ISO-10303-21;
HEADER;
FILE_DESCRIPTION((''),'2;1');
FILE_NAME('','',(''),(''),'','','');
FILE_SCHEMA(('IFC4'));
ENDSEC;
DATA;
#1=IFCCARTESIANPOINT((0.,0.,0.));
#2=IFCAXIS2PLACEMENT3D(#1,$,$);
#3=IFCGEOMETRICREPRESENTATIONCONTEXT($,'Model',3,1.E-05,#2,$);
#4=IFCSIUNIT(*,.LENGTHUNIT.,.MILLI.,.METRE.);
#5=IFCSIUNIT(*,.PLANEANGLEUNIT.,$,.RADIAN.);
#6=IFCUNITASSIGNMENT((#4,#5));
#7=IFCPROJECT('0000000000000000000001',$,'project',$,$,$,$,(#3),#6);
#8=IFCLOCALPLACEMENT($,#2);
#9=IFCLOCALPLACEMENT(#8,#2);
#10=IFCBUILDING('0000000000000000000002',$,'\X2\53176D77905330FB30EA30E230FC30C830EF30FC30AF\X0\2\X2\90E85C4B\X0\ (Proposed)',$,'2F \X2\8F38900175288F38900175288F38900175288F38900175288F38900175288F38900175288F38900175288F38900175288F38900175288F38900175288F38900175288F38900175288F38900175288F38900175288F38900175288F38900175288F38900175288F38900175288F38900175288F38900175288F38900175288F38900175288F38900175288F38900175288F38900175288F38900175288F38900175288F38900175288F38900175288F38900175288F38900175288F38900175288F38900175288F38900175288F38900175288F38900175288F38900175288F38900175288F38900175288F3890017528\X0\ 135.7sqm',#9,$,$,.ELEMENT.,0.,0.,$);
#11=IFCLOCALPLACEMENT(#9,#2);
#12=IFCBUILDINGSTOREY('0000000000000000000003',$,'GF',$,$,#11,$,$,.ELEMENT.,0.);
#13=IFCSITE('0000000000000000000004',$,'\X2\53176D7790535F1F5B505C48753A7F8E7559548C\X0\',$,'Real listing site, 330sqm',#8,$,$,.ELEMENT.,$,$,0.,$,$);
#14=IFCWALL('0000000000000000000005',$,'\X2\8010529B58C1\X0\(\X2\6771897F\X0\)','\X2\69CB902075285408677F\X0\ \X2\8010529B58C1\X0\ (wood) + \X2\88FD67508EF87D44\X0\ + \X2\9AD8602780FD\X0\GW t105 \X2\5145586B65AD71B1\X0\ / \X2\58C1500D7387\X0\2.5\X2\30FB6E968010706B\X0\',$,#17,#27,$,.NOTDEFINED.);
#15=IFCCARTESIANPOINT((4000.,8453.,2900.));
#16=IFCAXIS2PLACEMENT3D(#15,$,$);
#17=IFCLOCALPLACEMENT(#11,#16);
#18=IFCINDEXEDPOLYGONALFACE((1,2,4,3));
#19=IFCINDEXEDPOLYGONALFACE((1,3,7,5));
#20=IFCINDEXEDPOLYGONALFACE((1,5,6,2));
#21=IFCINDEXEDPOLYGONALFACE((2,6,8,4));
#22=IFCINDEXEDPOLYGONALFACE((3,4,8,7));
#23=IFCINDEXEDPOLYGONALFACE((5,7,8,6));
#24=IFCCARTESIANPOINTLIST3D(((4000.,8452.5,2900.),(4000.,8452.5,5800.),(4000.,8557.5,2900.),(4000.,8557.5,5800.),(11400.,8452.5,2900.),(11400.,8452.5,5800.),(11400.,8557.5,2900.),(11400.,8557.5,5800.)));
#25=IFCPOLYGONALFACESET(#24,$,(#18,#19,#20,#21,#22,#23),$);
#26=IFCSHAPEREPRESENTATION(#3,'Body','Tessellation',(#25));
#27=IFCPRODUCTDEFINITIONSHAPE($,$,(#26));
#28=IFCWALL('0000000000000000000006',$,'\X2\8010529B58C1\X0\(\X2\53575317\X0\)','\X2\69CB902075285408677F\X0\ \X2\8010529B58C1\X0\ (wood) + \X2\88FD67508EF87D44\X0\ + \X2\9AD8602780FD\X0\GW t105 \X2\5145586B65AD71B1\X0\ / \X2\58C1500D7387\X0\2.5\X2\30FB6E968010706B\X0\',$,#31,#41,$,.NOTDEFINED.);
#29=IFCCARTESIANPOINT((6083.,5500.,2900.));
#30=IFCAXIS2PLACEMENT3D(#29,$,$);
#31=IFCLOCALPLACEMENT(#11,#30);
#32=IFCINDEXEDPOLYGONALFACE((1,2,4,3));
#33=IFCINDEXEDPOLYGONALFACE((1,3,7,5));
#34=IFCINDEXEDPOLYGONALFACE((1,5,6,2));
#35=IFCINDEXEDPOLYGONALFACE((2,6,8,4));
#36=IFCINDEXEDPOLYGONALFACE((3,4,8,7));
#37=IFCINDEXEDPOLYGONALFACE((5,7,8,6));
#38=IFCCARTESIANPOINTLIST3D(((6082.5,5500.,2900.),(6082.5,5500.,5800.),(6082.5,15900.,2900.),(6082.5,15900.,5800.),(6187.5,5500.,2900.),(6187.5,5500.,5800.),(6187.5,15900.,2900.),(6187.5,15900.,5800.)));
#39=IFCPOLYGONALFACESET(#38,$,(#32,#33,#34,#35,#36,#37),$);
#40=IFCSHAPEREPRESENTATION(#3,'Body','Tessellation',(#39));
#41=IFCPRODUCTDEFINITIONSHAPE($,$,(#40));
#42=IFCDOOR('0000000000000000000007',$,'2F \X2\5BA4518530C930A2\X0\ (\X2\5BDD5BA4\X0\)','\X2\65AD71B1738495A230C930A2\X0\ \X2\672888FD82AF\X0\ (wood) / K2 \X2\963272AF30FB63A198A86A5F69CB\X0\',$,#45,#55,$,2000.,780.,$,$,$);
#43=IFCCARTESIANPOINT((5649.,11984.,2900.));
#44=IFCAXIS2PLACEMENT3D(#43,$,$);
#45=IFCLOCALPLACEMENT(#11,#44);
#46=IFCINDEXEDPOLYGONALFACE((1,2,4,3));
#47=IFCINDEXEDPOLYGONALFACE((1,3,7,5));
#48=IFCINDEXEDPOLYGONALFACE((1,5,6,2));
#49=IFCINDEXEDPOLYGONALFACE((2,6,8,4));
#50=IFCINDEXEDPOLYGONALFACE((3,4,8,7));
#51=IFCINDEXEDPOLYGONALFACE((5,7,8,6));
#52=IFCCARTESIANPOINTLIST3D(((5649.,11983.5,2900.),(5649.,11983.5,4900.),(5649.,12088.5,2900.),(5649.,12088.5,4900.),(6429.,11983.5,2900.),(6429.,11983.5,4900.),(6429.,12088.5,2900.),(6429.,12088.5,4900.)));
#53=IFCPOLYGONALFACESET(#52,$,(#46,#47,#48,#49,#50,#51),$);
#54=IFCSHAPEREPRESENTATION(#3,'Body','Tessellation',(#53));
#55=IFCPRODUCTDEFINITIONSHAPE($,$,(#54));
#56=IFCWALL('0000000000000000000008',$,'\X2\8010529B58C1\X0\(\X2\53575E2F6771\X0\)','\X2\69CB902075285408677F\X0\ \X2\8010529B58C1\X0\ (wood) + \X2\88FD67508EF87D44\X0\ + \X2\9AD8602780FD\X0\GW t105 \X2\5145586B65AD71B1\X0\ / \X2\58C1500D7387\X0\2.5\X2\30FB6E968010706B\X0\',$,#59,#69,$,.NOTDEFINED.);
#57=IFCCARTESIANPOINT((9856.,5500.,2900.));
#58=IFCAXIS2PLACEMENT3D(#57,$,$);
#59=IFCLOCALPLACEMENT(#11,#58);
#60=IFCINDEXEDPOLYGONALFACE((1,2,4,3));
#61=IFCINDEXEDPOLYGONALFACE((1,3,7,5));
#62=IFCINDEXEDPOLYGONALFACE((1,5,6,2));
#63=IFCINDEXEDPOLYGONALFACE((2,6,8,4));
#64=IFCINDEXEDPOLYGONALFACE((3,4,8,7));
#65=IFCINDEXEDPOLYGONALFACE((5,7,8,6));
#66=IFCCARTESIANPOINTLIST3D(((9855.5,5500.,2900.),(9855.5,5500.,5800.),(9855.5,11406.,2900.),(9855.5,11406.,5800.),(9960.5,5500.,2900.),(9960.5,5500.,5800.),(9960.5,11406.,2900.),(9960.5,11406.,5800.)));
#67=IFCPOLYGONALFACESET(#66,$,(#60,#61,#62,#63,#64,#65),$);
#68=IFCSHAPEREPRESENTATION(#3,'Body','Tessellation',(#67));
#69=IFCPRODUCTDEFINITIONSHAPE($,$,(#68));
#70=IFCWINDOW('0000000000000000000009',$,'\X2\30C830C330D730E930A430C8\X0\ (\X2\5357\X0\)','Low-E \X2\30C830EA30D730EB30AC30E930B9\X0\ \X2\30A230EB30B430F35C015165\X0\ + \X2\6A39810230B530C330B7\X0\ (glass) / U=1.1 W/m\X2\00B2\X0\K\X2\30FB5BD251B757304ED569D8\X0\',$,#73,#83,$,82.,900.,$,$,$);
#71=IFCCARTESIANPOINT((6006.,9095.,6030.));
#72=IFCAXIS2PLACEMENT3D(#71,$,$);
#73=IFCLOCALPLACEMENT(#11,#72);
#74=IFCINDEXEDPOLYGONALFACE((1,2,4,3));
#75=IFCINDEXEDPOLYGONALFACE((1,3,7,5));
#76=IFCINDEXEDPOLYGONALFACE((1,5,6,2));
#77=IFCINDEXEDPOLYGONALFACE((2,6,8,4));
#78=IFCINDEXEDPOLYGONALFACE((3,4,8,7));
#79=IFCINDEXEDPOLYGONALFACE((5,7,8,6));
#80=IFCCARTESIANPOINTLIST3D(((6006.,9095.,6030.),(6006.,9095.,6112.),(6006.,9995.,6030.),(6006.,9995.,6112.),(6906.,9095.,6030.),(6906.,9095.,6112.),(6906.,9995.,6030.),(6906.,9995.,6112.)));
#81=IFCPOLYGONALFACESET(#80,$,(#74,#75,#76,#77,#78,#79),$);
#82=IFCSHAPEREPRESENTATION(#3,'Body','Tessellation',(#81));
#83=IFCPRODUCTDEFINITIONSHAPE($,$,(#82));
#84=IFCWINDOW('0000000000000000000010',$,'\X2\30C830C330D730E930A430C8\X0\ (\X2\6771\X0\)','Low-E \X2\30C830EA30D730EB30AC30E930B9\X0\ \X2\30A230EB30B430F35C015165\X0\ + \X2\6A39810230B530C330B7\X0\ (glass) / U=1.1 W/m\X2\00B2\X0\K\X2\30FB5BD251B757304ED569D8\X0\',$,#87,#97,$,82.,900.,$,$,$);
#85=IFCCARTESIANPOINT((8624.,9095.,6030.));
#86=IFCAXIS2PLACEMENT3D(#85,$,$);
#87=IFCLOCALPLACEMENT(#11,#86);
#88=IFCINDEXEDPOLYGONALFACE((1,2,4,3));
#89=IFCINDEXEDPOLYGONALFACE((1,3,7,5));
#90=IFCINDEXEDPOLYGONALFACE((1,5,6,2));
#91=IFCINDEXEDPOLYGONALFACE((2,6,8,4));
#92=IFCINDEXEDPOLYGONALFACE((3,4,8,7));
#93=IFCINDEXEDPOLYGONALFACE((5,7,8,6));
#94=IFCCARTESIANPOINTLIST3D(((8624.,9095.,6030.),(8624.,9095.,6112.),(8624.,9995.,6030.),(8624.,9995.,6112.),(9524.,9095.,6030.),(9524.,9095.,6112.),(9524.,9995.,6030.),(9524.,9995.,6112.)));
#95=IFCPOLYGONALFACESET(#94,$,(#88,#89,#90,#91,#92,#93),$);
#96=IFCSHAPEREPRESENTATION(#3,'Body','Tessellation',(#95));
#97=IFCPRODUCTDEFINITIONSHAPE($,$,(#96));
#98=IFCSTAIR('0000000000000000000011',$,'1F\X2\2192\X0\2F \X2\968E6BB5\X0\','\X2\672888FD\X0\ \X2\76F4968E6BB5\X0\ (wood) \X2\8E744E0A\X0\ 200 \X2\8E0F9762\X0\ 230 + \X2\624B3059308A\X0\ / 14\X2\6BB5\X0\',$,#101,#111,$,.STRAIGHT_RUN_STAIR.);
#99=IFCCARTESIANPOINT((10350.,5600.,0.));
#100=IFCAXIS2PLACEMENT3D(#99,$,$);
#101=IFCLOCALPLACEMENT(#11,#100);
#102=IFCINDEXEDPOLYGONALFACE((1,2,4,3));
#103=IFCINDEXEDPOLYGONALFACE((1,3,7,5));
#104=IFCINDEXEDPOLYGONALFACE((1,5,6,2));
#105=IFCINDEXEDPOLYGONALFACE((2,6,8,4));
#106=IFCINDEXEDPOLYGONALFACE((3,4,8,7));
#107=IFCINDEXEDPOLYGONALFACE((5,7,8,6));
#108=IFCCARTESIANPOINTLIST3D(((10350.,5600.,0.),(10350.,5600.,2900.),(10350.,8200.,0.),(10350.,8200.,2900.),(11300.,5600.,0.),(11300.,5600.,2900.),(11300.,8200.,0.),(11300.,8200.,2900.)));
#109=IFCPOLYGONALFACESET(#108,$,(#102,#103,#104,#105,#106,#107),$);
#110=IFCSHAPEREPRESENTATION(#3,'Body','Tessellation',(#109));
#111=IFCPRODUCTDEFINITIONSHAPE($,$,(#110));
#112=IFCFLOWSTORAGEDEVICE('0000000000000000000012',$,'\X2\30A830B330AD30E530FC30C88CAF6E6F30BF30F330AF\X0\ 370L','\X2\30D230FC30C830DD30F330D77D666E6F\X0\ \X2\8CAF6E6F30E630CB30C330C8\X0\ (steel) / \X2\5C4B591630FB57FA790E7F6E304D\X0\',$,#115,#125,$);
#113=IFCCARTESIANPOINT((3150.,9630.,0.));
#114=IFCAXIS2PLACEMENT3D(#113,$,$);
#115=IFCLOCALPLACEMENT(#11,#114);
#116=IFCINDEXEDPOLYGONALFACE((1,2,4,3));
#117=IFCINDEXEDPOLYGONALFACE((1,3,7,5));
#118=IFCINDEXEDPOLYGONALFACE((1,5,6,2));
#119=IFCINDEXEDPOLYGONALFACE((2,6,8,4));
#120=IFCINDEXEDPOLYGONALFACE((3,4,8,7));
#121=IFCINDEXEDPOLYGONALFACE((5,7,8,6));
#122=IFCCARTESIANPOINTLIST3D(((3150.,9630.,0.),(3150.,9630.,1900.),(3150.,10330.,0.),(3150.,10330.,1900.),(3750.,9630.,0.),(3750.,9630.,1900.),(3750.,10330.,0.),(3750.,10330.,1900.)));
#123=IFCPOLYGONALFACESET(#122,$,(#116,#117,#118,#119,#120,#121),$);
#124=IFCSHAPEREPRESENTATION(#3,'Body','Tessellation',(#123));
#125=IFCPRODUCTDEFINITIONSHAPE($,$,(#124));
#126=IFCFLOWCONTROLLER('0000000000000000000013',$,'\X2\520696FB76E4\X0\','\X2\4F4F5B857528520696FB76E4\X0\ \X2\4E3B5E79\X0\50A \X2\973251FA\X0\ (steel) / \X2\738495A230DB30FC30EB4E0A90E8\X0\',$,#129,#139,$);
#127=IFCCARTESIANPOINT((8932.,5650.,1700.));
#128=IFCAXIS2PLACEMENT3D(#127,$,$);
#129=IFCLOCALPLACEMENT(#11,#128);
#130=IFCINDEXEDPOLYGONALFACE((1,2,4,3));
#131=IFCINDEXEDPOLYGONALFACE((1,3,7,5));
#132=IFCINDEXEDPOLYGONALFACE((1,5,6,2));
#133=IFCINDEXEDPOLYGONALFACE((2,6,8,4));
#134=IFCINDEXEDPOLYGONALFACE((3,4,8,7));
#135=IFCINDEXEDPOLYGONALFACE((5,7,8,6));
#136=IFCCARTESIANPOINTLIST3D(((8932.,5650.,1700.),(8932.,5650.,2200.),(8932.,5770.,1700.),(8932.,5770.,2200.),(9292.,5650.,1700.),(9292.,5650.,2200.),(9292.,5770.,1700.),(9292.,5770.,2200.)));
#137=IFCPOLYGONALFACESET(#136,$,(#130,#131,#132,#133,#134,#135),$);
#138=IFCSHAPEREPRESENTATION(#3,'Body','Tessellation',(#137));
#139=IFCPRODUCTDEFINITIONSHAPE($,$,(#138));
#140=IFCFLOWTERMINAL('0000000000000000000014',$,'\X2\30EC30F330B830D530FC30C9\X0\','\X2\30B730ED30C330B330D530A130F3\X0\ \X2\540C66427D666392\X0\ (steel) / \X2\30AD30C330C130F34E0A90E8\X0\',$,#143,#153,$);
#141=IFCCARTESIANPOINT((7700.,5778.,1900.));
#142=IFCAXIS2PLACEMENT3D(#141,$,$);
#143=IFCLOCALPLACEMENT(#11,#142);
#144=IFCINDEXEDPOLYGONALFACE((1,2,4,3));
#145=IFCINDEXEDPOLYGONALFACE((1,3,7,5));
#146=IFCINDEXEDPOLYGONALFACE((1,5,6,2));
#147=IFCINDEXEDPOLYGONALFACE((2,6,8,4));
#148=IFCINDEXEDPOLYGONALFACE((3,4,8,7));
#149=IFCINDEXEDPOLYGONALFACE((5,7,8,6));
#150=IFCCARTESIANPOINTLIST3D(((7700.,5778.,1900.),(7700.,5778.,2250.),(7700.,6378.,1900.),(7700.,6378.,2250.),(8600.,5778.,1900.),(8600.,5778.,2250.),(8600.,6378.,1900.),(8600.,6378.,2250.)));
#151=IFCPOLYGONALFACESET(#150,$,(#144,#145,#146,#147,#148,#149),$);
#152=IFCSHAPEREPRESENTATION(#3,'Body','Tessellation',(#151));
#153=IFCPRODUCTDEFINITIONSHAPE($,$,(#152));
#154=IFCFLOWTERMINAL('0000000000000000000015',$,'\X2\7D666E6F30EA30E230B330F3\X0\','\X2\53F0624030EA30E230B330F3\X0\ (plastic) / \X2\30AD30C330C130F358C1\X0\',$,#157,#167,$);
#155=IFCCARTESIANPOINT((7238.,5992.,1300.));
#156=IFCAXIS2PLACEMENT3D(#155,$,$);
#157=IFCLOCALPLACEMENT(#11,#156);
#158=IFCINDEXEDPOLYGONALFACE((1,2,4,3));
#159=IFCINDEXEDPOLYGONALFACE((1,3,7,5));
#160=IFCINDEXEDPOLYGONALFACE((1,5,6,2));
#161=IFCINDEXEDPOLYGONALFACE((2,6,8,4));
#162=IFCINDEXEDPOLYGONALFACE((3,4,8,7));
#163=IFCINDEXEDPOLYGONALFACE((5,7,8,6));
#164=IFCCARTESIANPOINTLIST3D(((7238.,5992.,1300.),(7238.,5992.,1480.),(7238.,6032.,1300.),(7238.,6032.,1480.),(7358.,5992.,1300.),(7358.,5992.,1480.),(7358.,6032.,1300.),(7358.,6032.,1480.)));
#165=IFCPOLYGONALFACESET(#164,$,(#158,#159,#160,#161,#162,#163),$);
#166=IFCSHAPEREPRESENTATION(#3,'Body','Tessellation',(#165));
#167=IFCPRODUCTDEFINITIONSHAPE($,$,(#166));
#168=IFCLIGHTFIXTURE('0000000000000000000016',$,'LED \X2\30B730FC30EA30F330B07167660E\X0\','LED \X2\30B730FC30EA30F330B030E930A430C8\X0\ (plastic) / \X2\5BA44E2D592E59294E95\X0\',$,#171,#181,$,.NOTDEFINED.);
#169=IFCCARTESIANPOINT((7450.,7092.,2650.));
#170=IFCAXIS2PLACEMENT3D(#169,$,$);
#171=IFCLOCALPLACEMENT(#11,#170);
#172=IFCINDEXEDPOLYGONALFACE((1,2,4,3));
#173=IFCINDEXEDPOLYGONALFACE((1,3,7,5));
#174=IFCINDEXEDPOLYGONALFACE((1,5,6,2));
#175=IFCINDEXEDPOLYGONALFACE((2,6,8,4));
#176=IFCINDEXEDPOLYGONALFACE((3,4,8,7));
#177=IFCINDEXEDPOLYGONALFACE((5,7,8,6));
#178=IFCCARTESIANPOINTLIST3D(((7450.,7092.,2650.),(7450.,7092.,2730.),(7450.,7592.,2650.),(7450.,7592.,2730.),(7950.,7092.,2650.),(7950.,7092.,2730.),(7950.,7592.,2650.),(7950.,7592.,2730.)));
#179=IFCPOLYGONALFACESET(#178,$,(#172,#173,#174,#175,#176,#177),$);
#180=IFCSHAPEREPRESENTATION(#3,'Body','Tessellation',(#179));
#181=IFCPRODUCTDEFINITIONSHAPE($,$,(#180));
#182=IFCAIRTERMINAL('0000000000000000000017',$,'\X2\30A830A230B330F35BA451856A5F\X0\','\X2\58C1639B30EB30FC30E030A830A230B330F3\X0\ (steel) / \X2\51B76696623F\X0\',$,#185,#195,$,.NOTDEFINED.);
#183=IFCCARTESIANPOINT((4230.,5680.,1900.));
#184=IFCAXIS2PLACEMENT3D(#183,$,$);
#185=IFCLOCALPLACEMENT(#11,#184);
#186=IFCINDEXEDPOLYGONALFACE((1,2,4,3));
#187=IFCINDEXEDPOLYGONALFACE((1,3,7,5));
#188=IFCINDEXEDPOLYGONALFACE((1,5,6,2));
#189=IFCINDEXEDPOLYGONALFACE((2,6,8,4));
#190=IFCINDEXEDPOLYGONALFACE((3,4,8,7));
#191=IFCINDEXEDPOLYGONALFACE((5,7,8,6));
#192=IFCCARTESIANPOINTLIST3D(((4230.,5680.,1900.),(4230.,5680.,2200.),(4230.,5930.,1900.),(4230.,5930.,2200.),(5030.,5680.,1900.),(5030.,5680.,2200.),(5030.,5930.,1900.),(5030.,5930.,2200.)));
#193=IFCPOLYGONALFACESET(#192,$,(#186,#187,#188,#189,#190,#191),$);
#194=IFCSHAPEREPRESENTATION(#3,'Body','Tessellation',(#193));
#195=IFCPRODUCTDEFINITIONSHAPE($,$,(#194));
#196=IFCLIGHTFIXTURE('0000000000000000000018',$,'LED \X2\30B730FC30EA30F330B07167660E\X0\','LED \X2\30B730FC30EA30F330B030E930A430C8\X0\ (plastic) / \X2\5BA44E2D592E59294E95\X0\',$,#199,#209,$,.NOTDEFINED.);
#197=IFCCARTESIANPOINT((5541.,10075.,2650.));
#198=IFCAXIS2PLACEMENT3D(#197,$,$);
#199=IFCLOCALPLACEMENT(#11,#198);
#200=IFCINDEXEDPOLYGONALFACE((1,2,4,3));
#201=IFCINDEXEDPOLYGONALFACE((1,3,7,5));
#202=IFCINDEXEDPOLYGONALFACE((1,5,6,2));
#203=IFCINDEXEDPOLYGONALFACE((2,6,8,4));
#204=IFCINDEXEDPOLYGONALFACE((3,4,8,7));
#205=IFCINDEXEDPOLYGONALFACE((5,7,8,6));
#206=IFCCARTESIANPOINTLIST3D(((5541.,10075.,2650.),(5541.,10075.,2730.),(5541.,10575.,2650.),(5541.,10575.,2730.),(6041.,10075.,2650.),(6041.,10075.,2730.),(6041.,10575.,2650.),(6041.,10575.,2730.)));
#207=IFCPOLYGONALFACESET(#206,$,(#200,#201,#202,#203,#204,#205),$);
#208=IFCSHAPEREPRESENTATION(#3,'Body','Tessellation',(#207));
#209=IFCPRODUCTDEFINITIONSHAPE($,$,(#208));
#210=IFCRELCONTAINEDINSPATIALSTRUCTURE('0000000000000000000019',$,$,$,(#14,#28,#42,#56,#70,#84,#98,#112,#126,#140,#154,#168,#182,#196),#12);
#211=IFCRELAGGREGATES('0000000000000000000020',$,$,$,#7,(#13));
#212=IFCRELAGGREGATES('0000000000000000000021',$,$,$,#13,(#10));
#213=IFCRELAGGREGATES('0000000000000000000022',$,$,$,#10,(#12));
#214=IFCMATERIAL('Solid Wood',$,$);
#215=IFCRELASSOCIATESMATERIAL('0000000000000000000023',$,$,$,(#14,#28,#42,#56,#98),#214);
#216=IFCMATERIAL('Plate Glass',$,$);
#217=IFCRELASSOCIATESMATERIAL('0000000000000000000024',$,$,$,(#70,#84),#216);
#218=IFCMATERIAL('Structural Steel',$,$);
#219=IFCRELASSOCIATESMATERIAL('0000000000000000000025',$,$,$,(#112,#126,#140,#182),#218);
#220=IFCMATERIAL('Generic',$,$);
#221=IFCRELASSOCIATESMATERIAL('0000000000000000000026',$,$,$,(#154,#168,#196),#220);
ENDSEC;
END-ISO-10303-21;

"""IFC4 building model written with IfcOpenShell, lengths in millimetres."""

from ifc_helpers import new_model, si_unit, frame, frame_2d, origin, place, context, project, spatial, rectangle, extrude, material, element, fill, save


model = new_model("IFC4")

# Units and contexts
model_context = context("Model", 3, precision=1e-05, world=origin())
ifc_project = project(units=[si_unit("LENGTHUNIT", "METRE", prefix="MILLI"), si_unit("PLANEANGLEUNIT", "RADIAN")], contexts=[model_context])

# Site, building, storey
site_placement = place(None, origin())
site = spatial("IfcSite", under=ifc_project, at=site_placement, Name="北海道弟子屈町美留和", ObjectType="Real listing site, 330sqm", CompositionType="ELEMENT", RefElevation=0.0)
building_placement = place(site_placement, origin())
building = spatial("IfcBuilding", under=site, at=building_placement, Name="北海道・リモートワーク2部屋 (Proposed)", ObjectType="2F 輸送用輸送用輸送用輸送用輸送用輸送用輸送用輸送用輸送用輸送用輸送用輸送用輸送用輸送用輸送用輸送用輸送用輸送用輸送用輸送用輸送用輸送用輸送用輸送用輸送用輸送用輸送用輸送用輸送用輸送用輸送用輸送用輸送用輸送用輸送用輸送用輸送用輸送用輸送用輸送用 135.7sqm", CompositionType="ELEMENT", ElevationOfRefHeight=0.0, ElevationOfTerrain=0.0)
storey_placement = place(building_placement, origin())
storey = spatial("IfcBuildingStorey", under=building, at=storey_placement, Name="GF", CompositionType="ELEMENT", Elevation=0.0)

# Shared definitions
ifc_material_1 = material(Name="Solid Wood")

# Wall
wall_1_placement = place(storey_placement, frame((4000.0, 8453.0, 2900.0)))
element("IfcWall", 1, at=wall_1_placement, inside=storey, material=ifc_material_1, Name="耐力壁(東西)", Description="構造用合板 耐力壁 (wood) + 製材軸組 + 高性能GW t105 充填断熱 / 壁倍率2.5・準耐火", PredefinedType="NOTDEFINED", context=model_context, shape_type="SweptSolid", body=[
    extrude(rectangle(XDim=7400.0, YDim=105.0, at=frame_2d((3700.0, 52.0))), frame((4000.0, 8453.0, 2900.0)), (0.0, 0.0, 1.0), 2900.0),
])

# Wall, opening, door
wall_2_placement = place(storey_placement, frame((6083.0, 5500.0, 2900.0)))
wall_2 = element("IfcWall", 2, at=wall_2_placement, inside=storey, material=ifc_material_1, Name="耐力壁(南北)", Description="構造用合板 耐力壁 (wood) + 製材軸組 + 高性能GW t105 充填断熱 / 壁倍率2.5・準耐火", PredefinedType="NOTDEFINED", context=model_context, shape_type="SweptSolid", body=[
    extrude(rectangle(XDim=105.0, YDim=10400.0, at=frame_2d((52.0, 5200.0))), frame((6083.0, 5500.0, 2900.0)), (0.0, 0.0, 1.0), 2900.0),
])
opening_placement = place(storey_placement, frame((5649.0, 11984.0, 2900.0)))
opening = element("IfcOpeningElement", 3, at=opening_placement, cuts=wall_2, PredefinedType="NOTDEFINED", context=model_context, shape_type="SweptSolid", body=[
    extrude(rectangle(XDim=780.0, YDim=105.0, at=frame_2d((390.0, 52.0))), frame((5649.0, 11984.0, 2900.0)), (0.0, 0.0, 1.0), 2000.0),
])
door_placement = place(storey_placement, frame((5649.0, 11984.0, 2900.0)))
door = element("IfcDoor", 4, at=door_placement, inside=storey, material=ifc_material_1, Name="2F 室内ドア (寝室)", Description="断熱玄関ドア 木製芯 (wood) / K2 防犯・採風機構", OverallHeight=2000.0, OverallWidth=780.0, context=model_context, shape_type="SweptSolid", body=[
    extrude(rectangle(XDim=780.0, YDim=105.0, at=frame_2d((390.0, 52.0))), frame((5649.0, 11984.0, 2900.0)), (0.0, 0.0, 1.0), 2000.0),
])
fill(opening, door)

# Wall
wall_3_placement = place(storey_placement, frame((9856.0, 5500.0, 2900.0)))
element("IfcWall", 5, at=wall_3_placement, inside=storey, material=ifc_material_1, Name="耐力壁(南帯東)", Description="構造用合板 耐力壁 (wood) + 製材軸組 + 高性能GW t105 充填断熱 / 壁倍率2.5・準耐火", PredefinedType="NOTDEFINED", context=model_context, shape_type="SweptSolid", body=[
    extrude(rectangle(XDim=105.0, YDim=5906.0, at=frame_2d((52.0, 2953.0))), frame((9856.0, 5500.0, 2900.0)), (0.0, 0.0, 1.0), 2900.0),
])

# Windows
ifc_material_2 = material(Name="Plate Glass")
window_1_placement = place(storey_placement, frame((6006.0, 9095.0, 6030.0)))
element("IfcWindow", 6, at=window_1_placement, inside=storey, material=ifc_material_2, Name="トップライト (南)", Description="Low-E トリプルガラス アルゴン封入 + 樹脂サッシ (glass) / U=1.1 W/m²K・寒冷地仕様", OverallHeight=82.0, OverallWidth=900.0, context=model_context, shape_type="SweptSolid", body=[
    extrude(rectangle(XDim=900.0, YDim=900.0, at=frame_2d((450.0, 450.0))), frame((6006.0, 9095.0, 6030.0)), (0.0, 0.0, 1.0), 82.0),
])
window_2_placement = place(storey_placement, frame((8624.0, 9095.0, 6030.0)))
element("IfcWindow", 7, at=window_2_placement, inside=storey, material=ifc_material_2, Name="トップライト (東)", Description="Low-E トリプルガラス アルゴン封入 + 樹脂サッシ (glass) / U=1.1 W/m²K・寒冷地仕様", OverallHeight=82.0, OverallWidth=900.0, context=model_context, shape_type="SweptSolid", body=[
    extrude(rectangle(XDim=900.0, YDim=900.0, at=frame_2d((450.0, 450.0))), frame((8624.0, 9095.0, 6030.0)), (0.0, 0.0, 1.0), 82.0),
])

# Stair
stair_placement = place(storey_placement, frame((10350.0, 5600.0, 0.0)))
element("IfcStair", 8, at=stair_placement, inside=storey, material=ifc_material_1, Name="1F→2F 階段", Description="木製 直階段 (wood) 蹴上 200 踏面 230 + 手すり / 14段", PredefinedType="STRAIGHT_RUN_STAIR", context=model_context, shape_type="SweptSolid", body=[
    extrude(rectangle(XDim=950.0, YDim=2600.0, at=frame_2d((475.0, 1300.0))), frame((10350.0, 5600.0, 0.0)), (0.0, 0.0, 1.0), 2900.0),
])

# Flow storage device
ifc_material_3 = material(Name="Structural Steel")
flow_storage_device_placement = place(storey_placement, frame((3150.0, 9630.0, 0.0)))
element("IfcFlowStorageDevice", 9, at=flow_storage_device_placement, inside=storey, material=ifc_material_3, Name="エコキュート貯湯タンク 370L", Description="ヒートポンプ給湯 貯湯ユニット (steel) / 屋外・基礎置き", context=model_context, shape_type="SweptSolid", body=[
    extrude(rectangle(XDim=600.0, YDim=700.0, at=frame_2d((300.0, 350.0))), frame((3150.0, 9630.0, 0.0)), (0.0, 0.0, 1.0), 1900.0),
])

# Flow controller
flow_controller_placement = place(storey_placement, frame((8932.0, 5650.0, 1700.0)))
element("IfcFlowController", 10, at=flow_controller_placement, inside=storey, material=ifc_material_3, Name="分電盤", Description="住宅用分電盤 主幹50A 露出 (steel) / 玄関ホール上部", context=model_context, shape_type="SweptSolid", body=[
    extrude(rectangle(XDim=360.0, YDim=120.0, at=frame_2d((180.0, 60.0))), frame((8932.0, 5650.0, 1700.0)), (0.0, 0.0, 1.0), 500.0),
])

# Flow terminals
flow_terminal_1_placement = place(storey_placement, frame((7700.0, 5778.0, 1900.0)))
element("IfcFlowTerminal", 11, at=flow_terminal_1_placement, inside=storey, material=ifc_material_3, Name="レンジフード", Description="シロッコファン 同時給排 (steel) / キッチン上部", context=model_context, shape_type="SweptSolid", body=[
    extrude(rectangle(XDim=900.0, YDim=600.0, at=frame_2d((450.0, 300.0))), frame((7700.0, 5778.0, 1900.0)), (0.0, 0.0, 1.0), 350.0),
])
ifc_material_4 = material(Name="Generic")
flow_terminal_2_placement = place(storey_placement, frame((7238.0, 5992.0, 1300.0)))
element("IfcFlowTerminal", 12, at=flow_terminal_2_placement, inside=storey, material=ifc_material_4, Name="給湯リモコン", Description="台所リモコン (plastic) / キッチン壁", context=model_context, shape_type="SweptSolid", body=[
    extrude(rectangle(XDim=120.0, YDim=40.0, at=frame_2d((60.0, 20.0))), frame((7238.0, 5992.0, 1300.0)), (0.0, 0.0, 1.0), 180.0),
])

# Light fixture
light_fixture_1_placement = place(storey_placement, frame((7450.0, 7092.0, 2650.0)))
element("IfcLightFixture", 13, at=light_fixture_1_placement, inside=storey, material=ifc_material_4, Name="LED シーリング照明", Description="LED シーリングライト (plastic) / 室中央天井", PredefinedType="NOTDEFINED", context=model_context, shape_type="SweptSolid", body=[
    extrude(rectangle(XDim=500.0, YDim=500.0, at=frame_2d((250.0, 250.0))), frame((7450.0, 7092.0, 2650.0)), (0.0, 0.0, 1.0), 80.0),
])

# Air terminal
air_terminal_1_placement = place(storey_placement, frame((4230.0, 5680.0, 1900.0)))
element("IfcAirTerminal", 14, at=air_terminal_1_placement, inside=storey, material=ifc_material_3, Name="エアコン室内機", Description="壁掛ルームエアコン (steel) / 冷暖房", PredefinedType="NOTDEFINED", context=model_context, shape_type="SweptSolid", body=[
    extrude(rectangle(XDim=800.0, YDim=250.0, at=frame_2d((400.0, 125.0))), frame((4230.0, 5680.0, 1900.0)), (0.0, 0.0, 1.0), 300.0),
])

# Light fixture
light_fixture_2_placement = place(storey_placement, frame((5541.0, 10075.0, 2650.0)))
element("IfcLightFixture", 15, at=light_fixture_2_placement, inside=storey, material=ifc_material_4, Name="LED シーリング照明", Description="LED シーリングライト (plastic) / 室中央天井", PredefinedType="NOTDEFINED", context=model_context, shape_type="SweptSolid", body=[
    extrude(rectangle(XDim=500.0, YDim=500.0, at=frame_2d((250.0, 250.0))), frame((5541.0, 10075.0, 2650.0)), (0.0, 0.0, 1.0), 80.0),
])

save(model, "model.ifc")
